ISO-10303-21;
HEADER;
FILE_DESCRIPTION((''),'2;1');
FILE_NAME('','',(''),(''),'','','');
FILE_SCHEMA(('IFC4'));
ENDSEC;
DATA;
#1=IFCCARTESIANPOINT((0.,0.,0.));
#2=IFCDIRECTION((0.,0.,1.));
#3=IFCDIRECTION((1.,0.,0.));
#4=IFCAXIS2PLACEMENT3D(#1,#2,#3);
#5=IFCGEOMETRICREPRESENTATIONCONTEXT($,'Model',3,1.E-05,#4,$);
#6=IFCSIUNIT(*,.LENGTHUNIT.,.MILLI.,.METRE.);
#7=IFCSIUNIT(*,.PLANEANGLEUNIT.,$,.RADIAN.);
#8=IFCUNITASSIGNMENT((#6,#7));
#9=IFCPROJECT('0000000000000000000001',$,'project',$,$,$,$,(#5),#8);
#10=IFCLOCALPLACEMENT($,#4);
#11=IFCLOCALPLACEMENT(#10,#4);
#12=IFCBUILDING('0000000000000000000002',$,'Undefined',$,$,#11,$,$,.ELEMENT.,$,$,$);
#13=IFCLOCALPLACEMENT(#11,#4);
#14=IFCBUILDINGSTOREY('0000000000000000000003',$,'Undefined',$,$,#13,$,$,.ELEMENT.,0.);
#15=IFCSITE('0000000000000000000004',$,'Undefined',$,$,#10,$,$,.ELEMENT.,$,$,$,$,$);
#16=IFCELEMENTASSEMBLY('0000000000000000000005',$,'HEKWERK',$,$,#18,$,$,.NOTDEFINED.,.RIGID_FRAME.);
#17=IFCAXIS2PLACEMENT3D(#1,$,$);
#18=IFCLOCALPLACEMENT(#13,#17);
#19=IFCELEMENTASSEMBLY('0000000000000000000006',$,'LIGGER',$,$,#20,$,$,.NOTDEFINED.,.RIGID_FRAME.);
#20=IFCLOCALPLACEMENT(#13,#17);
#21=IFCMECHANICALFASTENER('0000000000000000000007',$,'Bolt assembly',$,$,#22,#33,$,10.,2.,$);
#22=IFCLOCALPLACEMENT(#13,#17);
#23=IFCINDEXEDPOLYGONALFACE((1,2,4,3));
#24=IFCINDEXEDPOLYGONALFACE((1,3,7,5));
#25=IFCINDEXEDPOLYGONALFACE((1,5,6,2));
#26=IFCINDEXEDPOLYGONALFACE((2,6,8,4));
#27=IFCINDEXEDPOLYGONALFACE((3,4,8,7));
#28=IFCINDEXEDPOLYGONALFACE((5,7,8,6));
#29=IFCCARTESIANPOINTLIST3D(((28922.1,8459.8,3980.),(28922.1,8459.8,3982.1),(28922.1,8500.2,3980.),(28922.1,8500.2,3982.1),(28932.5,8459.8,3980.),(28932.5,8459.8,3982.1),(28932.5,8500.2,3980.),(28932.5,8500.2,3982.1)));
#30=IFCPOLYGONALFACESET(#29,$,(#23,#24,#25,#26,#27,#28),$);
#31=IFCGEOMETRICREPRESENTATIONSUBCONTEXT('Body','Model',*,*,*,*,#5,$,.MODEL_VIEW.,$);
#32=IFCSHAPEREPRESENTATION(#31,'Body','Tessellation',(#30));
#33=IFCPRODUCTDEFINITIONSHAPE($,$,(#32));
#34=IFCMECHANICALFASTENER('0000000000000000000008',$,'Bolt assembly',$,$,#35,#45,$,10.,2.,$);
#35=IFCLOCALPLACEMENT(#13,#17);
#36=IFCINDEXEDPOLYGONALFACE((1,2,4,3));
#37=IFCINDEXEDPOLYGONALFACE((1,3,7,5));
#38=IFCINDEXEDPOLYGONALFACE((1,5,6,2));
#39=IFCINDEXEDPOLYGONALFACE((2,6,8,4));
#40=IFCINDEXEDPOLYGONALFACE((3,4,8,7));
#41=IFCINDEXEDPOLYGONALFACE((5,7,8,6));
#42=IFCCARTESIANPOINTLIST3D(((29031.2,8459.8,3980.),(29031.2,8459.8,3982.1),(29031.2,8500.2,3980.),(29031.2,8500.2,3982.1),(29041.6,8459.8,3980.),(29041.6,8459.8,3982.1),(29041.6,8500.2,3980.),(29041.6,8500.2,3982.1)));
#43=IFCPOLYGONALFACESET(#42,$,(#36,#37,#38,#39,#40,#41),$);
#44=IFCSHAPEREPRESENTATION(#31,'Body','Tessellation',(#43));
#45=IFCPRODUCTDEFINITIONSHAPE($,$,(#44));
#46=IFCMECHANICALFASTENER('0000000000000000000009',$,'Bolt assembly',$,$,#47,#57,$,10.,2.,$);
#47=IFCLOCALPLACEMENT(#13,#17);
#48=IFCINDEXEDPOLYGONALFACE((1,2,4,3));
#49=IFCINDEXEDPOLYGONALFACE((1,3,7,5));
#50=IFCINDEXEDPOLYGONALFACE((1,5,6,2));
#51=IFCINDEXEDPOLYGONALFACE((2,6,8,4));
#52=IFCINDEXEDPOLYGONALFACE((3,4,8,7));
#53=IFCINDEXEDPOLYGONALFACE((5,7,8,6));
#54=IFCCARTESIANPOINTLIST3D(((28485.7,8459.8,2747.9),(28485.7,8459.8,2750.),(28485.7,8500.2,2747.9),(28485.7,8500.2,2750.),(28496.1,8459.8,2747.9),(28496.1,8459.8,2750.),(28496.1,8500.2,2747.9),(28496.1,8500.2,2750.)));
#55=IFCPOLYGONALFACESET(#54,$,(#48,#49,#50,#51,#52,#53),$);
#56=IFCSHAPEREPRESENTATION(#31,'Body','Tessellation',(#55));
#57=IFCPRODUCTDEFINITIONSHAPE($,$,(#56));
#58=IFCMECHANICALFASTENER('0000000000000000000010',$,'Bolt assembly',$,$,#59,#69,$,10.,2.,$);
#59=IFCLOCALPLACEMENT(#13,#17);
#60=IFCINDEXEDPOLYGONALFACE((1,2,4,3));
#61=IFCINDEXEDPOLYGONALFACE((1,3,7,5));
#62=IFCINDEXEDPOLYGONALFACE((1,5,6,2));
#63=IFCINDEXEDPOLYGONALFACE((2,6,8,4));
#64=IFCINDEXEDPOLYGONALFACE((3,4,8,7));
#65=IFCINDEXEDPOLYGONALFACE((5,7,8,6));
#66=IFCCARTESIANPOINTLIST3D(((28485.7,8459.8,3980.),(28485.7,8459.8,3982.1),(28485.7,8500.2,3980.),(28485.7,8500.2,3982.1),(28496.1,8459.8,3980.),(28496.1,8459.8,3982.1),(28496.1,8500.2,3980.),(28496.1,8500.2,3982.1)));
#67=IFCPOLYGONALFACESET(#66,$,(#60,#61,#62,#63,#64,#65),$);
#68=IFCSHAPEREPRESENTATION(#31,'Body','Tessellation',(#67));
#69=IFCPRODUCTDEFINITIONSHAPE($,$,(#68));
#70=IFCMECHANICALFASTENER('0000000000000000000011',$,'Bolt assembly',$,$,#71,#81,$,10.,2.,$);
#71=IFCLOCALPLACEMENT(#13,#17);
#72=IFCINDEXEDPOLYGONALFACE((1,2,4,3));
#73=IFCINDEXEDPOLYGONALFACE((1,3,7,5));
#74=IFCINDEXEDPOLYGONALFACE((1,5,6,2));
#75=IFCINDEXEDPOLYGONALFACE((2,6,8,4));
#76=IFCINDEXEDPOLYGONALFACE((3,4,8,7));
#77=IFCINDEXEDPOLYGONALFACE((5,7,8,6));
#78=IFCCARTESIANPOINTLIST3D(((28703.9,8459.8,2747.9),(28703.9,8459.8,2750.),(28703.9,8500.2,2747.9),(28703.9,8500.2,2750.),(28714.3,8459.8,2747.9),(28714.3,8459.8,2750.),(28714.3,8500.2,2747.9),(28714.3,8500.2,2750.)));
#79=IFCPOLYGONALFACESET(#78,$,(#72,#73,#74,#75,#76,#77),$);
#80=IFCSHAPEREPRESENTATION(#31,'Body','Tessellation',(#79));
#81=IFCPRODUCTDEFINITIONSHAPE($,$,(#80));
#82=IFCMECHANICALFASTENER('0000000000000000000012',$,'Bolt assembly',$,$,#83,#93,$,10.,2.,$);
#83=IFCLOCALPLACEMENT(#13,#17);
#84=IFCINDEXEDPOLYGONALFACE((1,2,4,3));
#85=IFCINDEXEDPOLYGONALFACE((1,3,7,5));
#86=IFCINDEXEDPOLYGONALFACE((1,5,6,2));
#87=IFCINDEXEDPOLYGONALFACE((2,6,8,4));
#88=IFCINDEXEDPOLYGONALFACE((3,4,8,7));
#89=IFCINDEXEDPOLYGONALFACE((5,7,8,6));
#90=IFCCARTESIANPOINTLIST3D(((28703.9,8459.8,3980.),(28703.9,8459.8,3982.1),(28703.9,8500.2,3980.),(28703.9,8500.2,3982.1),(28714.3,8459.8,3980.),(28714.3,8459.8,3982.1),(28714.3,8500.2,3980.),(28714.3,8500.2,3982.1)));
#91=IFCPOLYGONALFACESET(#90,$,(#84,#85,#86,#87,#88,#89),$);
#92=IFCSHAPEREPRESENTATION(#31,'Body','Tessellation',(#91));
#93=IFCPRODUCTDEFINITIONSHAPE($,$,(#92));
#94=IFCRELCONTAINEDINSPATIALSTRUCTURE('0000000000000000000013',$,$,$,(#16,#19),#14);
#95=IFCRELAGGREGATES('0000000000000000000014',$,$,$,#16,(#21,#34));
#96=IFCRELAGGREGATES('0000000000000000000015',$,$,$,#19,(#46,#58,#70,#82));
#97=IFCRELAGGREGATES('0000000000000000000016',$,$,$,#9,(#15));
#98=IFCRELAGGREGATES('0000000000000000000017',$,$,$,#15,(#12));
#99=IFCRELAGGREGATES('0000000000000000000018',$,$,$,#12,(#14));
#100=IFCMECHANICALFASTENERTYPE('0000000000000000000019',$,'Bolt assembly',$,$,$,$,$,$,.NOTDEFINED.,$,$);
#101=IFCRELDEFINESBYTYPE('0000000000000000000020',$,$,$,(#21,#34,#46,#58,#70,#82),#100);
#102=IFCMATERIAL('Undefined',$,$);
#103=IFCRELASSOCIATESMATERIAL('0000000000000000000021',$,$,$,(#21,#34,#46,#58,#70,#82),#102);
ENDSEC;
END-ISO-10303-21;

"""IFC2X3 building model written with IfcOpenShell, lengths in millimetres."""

from ifc_helpers import new_model, si_unit, frame, origin_with_axes, place, context, subcontext, project, spatial, polyline, segment, composite_curve, outline, extrude, source, transform, mapped, material, type_object, element, aggregate, save


model = new_model("IFC2X3")

# Units and contexts
model_context = context("Model", 3, precision=1e-05, world=origin_with_axes())
body_context = subcontext(model_context, "Body", "Model", "MODEL_VIEW")
ifc_project = project(units=[si_unit("LENGTHUNIT", "METRE", prefix="MILLI"), si_unit("PLANEANGLEUNIT", "RADIAN")], contexts=[model_context])

# Site, building, storey
site_placement = place(None, origin_with_axes())
site = spatial("IfcSite", under=ifc_project, at=site_placement, Name="Undefined", CompositionType="ELEMENT")
building_placement = place(site_placement, origin_with_axes())
building = spatial("IfcBuilding", under=site, at=building_placement, Name="Undefined", CompositionType="ELEMENT")
storey_placement = place(building_placement, origin_with_axes())
storey = spatial("IfcBuildingStorey", under=building, at=storey_placement, Name="Undefined", CompositionType="ELEMENT", Elevation=0.0)

# Element assemblies
assembly_1_placement = place(storey_placement, origin_with_axes())
assembly_1 = element("IfcElementAssembly", 1, at=assembly_1_placement, inside=storey, Name="HEKWERK", AssemblyPlace="NOTDEFINED", PredefinedType="RIGID_FRAME")
assembly_2_placement = place(storey_placement, origin_with_axes())
assembly_2 = element("IfcElementAssembly", 2, at=assembly_2_placement, inside=storey, Name="LIGGER", AssemblyPlace="NOTDEFINED", PredefinedType="RIGID_FRAME")

# Mechanical fasteners
ifc_material_1 = material(Name="Undefined")
mechanical_fastener_type = type_object("IfcMechanicalFastenerType", Name="Bolt assembly")
shared_shape_1 = source(origin_with_axes(), body_context, "Body", "SweptSolid", [
    extrude(outline(composite_curve([segment(polyline([(-20.2, 5.2), (20.2, 5.2)]), True, "CONTINUOUS"), segment(polyline([(20.2, 5.2), (20.2, -5.2)]), True, "CONTINUOUS"), segment(polyline([(20.2, -5.2), (-20.2, -5.2)]), True, "CONTINUOUS"), segment(polyline([(-20.2, -5.2), (-20.2, 5.2)]), True, "CONTINUOUS")], self_intersect=False)), frame((0.0, -1.0, 0.0), z_axis=(0.0, 1.0, 0.0), x_axis=(1.0, 0.0, 0.0)), (0.0, 0.0, 1.0), 2.1),
])
mechanical_fastener_1_placement = place(assembly_1_placement, frame((28927.3, 8480.0, 3981.0), z_axis=(-1.0, 0.0, 0.0), x_axis=(0.0, -1.0, 0.0)))
mechanical_fastener_1 = element("IfcMechanicalFastener", 3, at=mechanical_fastener_1_placement, type_object=mechanical_fastener_type, material=ifc_material_1, Name="Bolt assembly", NominalDiameter=10.0, NominalLength=2.0, context=body_context, shape_type="MappedRepresentation", body=[
    mapped(shared_shape_1, transform((0.0, 0.0, 0.0))),
])
shared_shape_2 = source(origin_with_axes(), body_context, "Body", "SweptSolid", [
    extrude(outline(composite_curve([segment(polyline([(-20.2, 5.2), (20.2, 5.2)]), True, "CONTINUOUS"), segment(polyline([(20.2, 5.2), (20.2, -5.2)]), True, "CONTINUOUS"), segment(polyline([(20.2, -5.2), (-20.2, -5.2)]), True, "CONTINUOUS"), segment(polyline([(-20.2, -5.2), (-20.2, 5.2)]), True, "CONTINUOUS")], self_intersect=False)), frame((0.0, -1.0, 0.0), z_axis=(0.0, 1.0, 0.0), x_axis=(1.0, 0.0, 0.0)), (0.0, 0.0, 1.0), 2.1),
])
mechanical_fastener_2_placement = place(assembly_1_placement, frame((29036.4, 8480.0, 3981.0), z_axis=(-1.0, 0.0, 0.0), x_axis=(0.0, -1.0, 0.0)))
mechanical_fastener_2 = element("IfcMechanicalFastener", 4, at=mechanical_fastener_2_placement, type_object=mechanical_fastener_type, material=ifc_material_1, Name="Bolt assembly", NominalDiameter=10.0, NominalLength=2.0, context=body_context, shape_type="MappedRepresentation", body=[
    mapped(shared_shape_2, transform((0.0, 0.0, 0.0))),
])
aggregate(assembly_1, [mechanical_fastener_1, mechanical_fastener_2])
shared_shape_3 = source(origin_with_axes(), body_context, "Body", "SweptSolid", [
    extrude(outline(composite_curve([segment(polyline([(-20.2, 5.2), (20.2, 5.2)]), True, "CONTINUOUS"), segment(polyline([(20.2, 5.2), (20.2, -5.2)]), True, "CONTINUOUS"), segment(polyline([(20.2, -5.2), (-20.2, -5.2)]), True, "CONTINUOUS"), segment(polyline([(-20.2, -5.2), (-20.2, 5.2)]), True, "CONTINUOUS")], self_intersect=False)), frame((0.0, -1.0, 0.0), z_axis=(0.0, 1.0, 0.0), x_axis=(1.0, 0.0, 0.0)), (0.0, 0.0, 1.0), 2.1),
])
mechanical_fastener_3_placement = place(assembly_2_placement, frame((28490.9, 8480.0, 2749.0), z_axis=(1.0, 0.0, 0.0), x_axis=(0.0, -1.0, 0.0)))
mechanical_fastener_3 = element("IfcMechanicalFastener", 5, at=mechanical_fastener_3_placement, type_object=mechanical_fastener_type, material=ifc_material_1, Name="Bolt assembly", NominalDiameter=10.0, NominalLength=2.0, context=body_context, shape_type="MappedRepresentation", body=[
    mapped(shared_shape_3, transform((0.0, 0.0, 0.0))),
])
shared_shape_4 = source(origin_with_axes(), body_context, "Body", "SweptSolid", [
    extrude(outline(composite_curve([segment(polyline([(-20.2, 5.2), (20.2, 5.2)]), True, "CONTINUOUS"), segment(polyline([(20.2, 5.2), (20.2, -5.2)]), True, "CONTINUOUS"), segment(polyline([(20.2, -5.2), (-20.2, -5.2)]), True, "CONTINUOUS"), segment(polyline([(-20.2, -5.2), (-20.2, 5.2)]), True, "CONTINUOUS")], self_intersect=False)), frame((0.0, -1.0, 0.0), z_axis=(0.0, 1.0, 0.0), x_axis=(1.0, 0.0, 0.0)), (0.0, 0.0, 1.0), 2.1),
])
mechanical_fastener_4_placement = place(assembly_2_placement, frame((28490.9, 8480.0, 3981.0), z_axis=(-1.0, 0.0, 0.0), x_axis=(0.0, -1.0, 0.0)))
mechanical_fastener_4 = element("IfcMechanicalFastener", 6, at=mechanical_fastener_4_placement, type_object=mechanical_fastener_type, material=ifc_material_1, Name="Bolt assembly", NominalDiameter=10.0, NominalLength=2.0, context=body_context, shape_type="MappedRepresentation", body=[
    mapped(shared_shape_4, transform((0.0, 0.0, 0.0))),
])
shared_shape_5 = source(origin_with_axes(), body_context, "Body", "SweptSolid", [
    extrude(outline(composite_curve([segment(polyline([(-20.2, 5.2), (20.2, 5.2)]), True, "CONTINUOUS"), segment(polyline([(20.2, 5.2), (20.2, -5.2)]), True, "CONTINUOUS"), segment(polyline([(20.2, -5.2), (-20.2, -5.2)]), True, "CONTINUOUS"), segment(polyline([(-20.2, -5.2), (-20.2, 5.2)]), True, "CONTINUOUS")], self_intersect=False)), frame((0.0, -1.0, 0.0), z_axis=(0.0, 1.0, 0.0), x_axis=(1.0, 0.0, 0.0)), (0.0, 0.0, 1.0), 2.1),
])
mechanical_fastener_5_placement = place(assembly_2_placement, frame((28709.1, 8480.0, 2749.0), z_axis=(1.0, 0.0, 0.0), x_axis=(0.0, -1.0, 0.0)))
mechanical_fastener_5 = element("IfcMechanicalFastener", 7, at=mechanical_fastener_5_placement, type_object=mechanical_fastener_type, material=ifc_material_1, Name="Bolt assembly", NominalDiameter=10.0, NominalLength=2.0, context=body_context, shape_type="MappedRepresentation", body=[
    mapped(shared_shape_5, transform((0.0, 0.0, 0.0))),
])
shared_shape_6 = source(origin_with_axes(), body_context, "Body", "SweptSolid", [
    extrude(outline(composite_curve([segment(polyline([(-20.2, 5.2), (20.2, 5.2)]), True, "CONTINUOUS"), segment(polyline([(20.2, 5.2), (20.2, -5.2)]), True, "CONTINUOUS"), segment(polyline([(20.2, -5.2), (-20.2, -5.2)]), True, "CONTINUOUS"), segment(polyline([(-20.2, -5.2), (-20.2, 5.2)]), True, "CONTINUOUS")], self_intersect=False)), frame((0.0, -1.0, 0.0), z_axis=(0.0, 1.0, 0.0), x_axis=(1.0, 0.0, 0.0)), (0.0, 0.0, 1.0), 2.1),
])
mechanical_fastener_6_placement = place(assembly_2_placement, frame((28709.1, 8480.0, 3981.0), z_axis=(-1.0, 0.0, 0.0), x_axis=(0.0, -1.0, 0.0)))
mechanical_fastener_6 = element("IfcMechanicalFastener", 8, at=mechanical_fastener_6_placement, type_object=mechanical_fastener_type, material=ifc_material_1, Name="Bolt assembly", NominalDiameter=10.0, NominalLength=2.0, context=body_context, shape_type="MappedRepresentation", body=[
    mapped(shared_shape_6, transform((0.0, 0.0, 0.0))),
])
aggregate(assembly_2, [mechanical_fastener_3, mechanical_fastener_4, mechanical_fastener_5, mechanical_fastener_6])

save(model, "model.ifc")
